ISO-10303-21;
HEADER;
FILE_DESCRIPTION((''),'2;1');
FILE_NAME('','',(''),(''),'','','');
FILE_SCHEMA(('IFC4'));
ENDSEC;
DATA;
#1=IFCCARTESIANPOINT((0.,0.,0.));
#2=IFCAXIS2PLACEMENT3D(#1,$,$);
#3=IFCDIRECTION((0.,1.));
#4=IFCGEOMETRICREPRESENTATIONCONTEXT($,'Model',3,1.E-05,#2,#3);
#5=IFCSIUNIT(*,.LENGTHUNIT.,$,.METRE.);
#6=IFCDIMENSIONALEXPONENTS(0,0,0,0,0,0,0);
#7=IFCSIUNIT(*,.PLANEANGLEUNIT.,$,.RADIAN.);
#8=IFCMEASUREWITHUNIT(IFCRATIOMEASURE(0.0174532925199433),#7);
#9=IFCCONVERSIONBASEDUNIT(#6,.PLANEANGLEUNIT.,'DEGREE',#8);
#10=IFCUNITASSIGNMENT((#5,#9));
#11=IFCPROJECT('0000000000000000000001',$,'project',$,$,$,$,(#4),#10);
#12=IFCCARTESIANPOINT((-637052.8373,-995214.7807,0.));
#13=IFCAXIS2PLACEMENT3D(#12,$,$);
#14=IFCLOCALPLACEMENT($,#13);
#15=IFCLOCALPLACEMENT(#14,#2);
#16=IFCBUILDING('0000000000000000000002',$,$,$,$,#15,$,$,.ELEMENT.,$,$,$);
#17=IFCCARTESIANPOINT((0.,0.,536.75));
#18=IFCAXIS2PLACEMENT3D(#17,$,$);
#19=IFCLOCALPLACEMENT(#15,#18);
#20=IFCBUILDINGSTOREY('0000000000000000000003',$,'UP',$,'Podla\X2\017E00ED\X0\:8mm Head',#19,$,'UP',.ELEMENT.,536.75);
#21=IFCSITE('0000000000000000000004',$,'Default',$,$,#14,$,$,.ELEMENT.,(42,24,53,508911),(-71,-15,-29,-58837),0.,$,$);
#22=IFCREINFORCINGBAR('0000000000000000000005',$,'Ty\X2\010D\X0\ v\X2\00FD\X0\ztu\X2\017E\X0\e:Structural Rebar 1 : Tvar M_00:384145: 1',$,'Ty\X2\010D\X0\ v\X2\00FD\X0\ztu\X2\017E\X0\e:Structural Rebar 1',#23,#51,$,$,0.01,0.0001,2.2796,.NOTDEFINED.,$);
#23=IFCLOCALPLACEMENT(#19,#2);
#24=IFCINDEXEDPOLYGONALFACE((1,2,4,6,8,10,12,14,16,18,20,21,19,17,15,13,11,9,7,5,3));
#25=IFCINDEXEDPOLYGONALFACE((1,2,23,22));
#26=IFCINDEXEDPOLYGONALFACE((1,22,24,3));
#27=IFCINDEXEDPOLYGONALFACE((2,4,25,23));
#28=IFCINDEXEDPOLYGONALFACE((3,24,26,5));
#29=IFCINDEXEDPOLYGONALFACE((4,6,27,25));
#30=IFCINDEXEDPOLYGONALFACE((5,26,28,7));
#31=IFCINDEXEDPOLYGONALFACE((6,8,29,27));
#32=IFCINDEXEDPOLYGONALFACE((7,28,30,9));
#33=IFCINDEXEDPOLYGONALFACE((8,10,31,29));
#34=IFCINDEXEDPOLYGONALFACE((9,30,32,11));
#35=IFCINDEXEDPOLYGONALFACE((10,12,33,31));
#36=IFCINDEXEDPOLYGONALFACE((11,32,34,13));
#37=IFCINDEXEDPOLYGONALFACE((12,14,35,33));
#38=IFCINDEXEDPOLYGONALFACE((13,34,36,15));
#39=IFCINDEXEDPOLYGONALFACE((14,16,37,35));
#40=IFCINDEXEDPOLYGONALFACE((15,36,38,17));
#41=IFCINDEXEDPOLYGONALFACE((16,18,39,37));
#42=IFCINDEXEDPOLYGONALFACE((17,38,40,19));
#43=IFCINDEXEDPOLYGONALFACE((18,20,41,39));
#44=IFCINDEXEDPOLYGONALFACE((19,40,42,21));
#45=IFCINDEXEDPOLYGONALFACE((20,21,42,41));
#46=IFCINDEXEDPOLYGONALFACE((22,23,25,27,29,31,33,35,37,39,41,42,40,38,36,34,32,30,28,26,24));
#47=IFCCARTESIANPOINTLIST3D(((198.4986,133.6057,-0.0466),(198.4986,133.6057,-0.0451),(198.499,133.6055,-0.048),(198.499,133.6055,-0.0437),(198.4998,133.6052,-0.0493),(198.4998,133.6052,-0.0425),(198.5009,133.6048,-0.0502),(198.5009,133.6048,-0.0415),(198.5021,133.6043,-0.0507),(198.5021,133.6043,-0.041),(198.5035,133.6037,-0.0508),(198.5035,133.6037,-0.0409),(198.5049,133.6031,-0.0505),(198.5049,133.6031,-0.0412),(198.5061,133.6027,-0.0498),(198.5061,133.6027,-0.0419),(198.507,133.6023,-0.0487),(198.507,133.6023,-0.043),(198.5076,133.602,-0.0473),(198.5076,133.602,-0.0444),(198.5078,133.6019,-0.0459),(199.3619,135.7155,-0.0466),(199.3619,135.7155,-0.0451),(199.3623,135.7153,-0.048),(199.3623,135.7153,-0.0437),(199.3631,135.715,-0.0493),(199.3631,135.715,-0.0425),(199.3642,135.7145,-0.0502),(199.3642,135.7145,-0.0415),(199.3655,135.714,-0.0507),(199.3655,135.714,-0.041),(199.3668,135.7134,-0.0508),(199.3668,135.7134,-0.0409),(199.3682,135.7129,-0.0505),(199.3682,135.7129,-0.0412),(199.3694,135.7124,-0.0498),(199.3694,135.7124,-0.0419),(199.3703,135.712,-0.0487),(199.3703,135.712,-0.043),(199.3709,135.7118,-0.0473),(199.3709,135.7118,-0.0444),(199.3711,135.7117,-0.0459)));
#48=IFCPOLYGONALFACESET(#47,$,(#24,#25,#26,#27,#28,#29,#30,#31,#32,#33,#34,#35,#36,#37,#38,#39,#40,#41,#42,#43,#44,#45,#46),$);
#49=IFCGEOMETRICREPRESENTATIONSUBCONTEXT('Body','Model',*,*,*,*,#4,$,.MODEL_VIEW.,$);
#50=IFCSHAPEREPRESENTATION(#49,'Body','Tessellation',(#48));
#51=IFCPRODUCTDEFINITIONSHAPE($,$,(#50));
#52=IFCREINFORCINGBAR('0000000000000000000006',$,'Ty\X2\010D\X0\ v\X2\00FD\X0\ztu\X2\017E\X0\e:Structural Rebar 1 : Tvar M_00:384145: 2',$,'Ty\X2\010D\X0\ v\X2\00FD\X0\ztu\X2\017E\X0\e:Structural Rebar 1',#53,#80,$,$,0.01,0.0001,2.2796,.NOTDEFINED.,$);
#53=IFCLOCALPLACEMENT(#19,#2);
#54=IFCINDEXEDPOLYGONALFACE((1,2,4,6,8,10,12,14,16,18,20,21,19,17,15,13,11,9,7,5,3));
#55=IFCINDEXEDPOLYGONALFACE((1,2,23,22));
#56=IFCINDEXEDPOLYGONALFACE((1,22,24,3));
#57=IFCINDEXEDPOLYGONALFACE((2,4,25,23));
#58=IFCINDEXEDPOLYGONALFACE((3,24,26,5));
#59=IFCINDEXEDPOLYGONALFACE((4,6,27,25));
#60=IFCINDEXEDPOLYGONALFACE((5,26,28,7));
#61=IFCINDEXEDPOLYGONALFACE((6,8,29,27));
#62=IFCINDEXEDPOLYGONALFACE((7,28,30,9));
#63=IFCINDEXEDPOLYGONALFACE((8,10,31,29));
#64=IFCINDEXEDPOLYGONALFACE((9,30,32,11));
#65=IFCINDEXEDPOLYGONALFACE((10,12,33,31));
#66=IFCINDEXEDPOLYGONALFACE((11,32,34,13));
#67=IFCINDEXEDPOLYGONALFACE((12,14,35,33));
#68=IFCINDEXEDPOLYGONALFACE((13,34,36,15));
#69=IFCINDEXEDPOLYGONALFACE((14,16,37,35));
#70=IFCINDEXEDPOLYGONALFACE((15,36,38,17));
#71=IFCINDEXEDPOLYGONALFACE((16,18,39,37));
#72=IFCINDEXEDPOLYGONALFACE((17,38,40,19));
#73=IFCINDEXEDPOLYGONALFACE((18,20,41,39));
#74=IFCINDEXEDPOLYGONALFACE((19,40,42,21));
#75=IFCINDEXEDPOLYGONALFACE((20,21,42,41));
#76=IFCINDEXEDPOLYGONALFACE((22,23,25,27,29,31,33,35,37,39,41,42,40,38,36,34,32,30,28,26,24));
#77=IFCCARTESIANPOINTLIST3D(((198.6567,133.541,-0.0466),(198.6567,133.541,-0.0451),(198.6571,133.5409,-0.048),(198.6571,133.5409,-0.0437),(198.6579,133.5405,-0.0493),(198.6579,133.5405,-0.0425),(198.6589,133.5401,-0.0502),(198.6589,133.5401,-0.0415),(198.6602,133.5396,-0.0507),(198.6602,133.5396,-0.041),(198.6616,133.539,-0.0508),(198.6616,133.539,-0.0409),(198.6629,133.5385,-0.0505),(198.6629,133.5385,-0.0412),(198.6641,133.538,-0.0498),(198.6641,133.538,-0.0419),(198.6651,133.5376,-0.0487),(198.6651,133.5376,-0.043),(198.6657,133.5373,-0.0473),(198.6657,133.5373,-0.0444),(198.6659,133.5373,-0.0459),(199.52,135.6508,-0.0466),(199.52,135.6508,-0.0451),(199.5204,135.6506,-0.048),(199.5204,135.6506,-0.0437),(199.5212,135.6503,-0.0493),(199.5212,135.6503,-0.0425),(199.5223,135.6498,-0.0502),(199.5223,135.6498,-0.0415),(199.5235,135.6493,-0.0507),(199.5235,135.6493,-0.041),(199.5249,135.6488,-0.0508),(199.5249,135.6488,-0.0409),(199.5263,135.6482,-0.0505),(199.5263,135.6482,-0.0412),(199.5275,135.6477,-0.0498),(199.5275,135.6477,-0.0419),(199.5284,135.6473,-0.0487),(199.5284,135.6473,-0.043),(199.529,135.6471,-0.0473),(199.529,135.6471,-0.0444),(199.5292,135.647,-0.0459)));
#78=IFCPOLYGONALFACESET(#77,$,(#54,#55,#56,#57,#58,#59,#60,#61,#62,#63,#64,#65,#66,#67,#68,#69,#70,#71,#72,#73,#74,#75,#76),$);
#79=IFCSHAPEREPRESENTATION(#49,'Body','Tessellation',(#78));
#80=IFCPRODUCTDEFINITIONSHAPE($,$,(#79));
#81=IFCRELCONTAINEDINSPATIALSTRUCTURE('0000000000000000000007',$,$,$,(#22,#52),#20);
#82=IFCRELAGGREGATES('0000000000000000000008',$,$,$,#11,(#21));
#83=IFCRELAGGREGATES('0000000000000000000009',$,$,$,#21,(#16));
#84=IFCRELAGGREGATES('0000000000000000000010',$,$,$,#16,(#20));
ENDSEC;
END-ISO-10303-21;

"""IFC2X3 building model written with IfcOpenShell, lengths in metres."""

from ifc_helpers import new_model, entity, si_unit, converted_unit, direction, frame, origin, place, context, subcontext, project, spatial, element, save


model = new_model("IFC2X3")

# Units and contexts
model_context = context("Model", 3, precision=1e-05, world=origin(), true_north=direction((0.0, 1.0)))
body_context = subcontext(model_context, "Body", "Model", "MODEL_VIEW")
ifc_project = project(units=[si_unit("LENGTHUNIT", "METRE"), converted_unit("PLANEANGLEUNIT", "DEGREE", entity("IfcRatioMeasure", 0.0174532925199433), si_unit("PLANEANGLEUNIT", "RADIAN"), dimensions=[0, 0, 0, 0, 0, 0, 0])], contexts=[model_context])

# Site, building, storey
site_placement = place(None, frame((-637052.8373, -995214.7807, 0.0)))
site = spatial("IfcSite", under=ifc_project, at=site_placement, Name="Default", CompositionType="ELEMENT", RefLatitude=(42, 24, 53, 508911), RefLongitude=(-71, -15, -29, -58837), RefElevation=0.0)
building_placement = place(site_placement, origin())
building = spatial("IfcBuilding", under=site, at=building_placement, CompositionType="ELEMENT")
storey_placement = place(building_placement, frame((0.0, 0.0, 536.75)))
storey = spatial("IfcBuildingStorey", under=building, at=storey_placement, Name="UP", ObjectType="Podlaží:8mm Head", LongName="UP", CompositionType="ELEMENT", Elevation=536.75)

# Reinforcing bars
reinforcing_bar_1_placement = place(storey_placement, origin())
element("IfcReinforcingBar", 1, at=reinforcing_bar_1_placement, inside=storey, Name="Tyč výztuže:Structural Rebar 1 : Tvar M_00:384145: 1", ObjectType="Tyč výztuže:Structural Rebar 1", BarLength=2.2796, BarRole="NOTDEFINED", CrossSectionArea=0.0001, NominalDiameter=0.01, context=body_context, shape_type="AdvancedSweptSolid", body=[
    entity("IfcSweptDiskSolid", entity("IfcCompositeCurve", [entity("IfcCompositeCurveSegment", "CONTINUOUS", True, entity("IfcPolyline", [entity("IfcCartesianPoint", [-199.3665, -135.7136, 0.0459]), entity("IfcCartesianPoint", [-198.5032, -133.6038, 0.0459])]))], False), 0.005, None, 0.0, 1.0),
])
reinforcing_bar_2_placement = place(storey_placement, origin())
element("IfcReinforcingBar", 2, at=reinforcing_bar_2_placement, inside=storey, Name="Tyč výztuže:Structural Rebar 1 : Tvar M_00:384145: 2", ObjectType="Tyč výztuže:Structural Rebar 1", BarLength=2.2796, BarRole="NOTDEFINED", CrossSectionArea=0.0001, NominalDiameter=0.01, context=body_context, shape_type="AdvancedSweptSolid", body=[
    entity("IfcSweptDiskSolid", entity("IfcCompositeCurve", [entity("IfcCompositeCurveSegment", "CONTINUOUS", True, entity("IfcPolyline", [entity("IfcCartesianPoint", [-199.5246, -135.6489, 0.0459]), entity("IfcCartesianPoint", [-198.6612, -133.5391, 0.0459])]))], False), 0.005, None, 0.0, 1.0),
])

save(model, "model.ifc")
